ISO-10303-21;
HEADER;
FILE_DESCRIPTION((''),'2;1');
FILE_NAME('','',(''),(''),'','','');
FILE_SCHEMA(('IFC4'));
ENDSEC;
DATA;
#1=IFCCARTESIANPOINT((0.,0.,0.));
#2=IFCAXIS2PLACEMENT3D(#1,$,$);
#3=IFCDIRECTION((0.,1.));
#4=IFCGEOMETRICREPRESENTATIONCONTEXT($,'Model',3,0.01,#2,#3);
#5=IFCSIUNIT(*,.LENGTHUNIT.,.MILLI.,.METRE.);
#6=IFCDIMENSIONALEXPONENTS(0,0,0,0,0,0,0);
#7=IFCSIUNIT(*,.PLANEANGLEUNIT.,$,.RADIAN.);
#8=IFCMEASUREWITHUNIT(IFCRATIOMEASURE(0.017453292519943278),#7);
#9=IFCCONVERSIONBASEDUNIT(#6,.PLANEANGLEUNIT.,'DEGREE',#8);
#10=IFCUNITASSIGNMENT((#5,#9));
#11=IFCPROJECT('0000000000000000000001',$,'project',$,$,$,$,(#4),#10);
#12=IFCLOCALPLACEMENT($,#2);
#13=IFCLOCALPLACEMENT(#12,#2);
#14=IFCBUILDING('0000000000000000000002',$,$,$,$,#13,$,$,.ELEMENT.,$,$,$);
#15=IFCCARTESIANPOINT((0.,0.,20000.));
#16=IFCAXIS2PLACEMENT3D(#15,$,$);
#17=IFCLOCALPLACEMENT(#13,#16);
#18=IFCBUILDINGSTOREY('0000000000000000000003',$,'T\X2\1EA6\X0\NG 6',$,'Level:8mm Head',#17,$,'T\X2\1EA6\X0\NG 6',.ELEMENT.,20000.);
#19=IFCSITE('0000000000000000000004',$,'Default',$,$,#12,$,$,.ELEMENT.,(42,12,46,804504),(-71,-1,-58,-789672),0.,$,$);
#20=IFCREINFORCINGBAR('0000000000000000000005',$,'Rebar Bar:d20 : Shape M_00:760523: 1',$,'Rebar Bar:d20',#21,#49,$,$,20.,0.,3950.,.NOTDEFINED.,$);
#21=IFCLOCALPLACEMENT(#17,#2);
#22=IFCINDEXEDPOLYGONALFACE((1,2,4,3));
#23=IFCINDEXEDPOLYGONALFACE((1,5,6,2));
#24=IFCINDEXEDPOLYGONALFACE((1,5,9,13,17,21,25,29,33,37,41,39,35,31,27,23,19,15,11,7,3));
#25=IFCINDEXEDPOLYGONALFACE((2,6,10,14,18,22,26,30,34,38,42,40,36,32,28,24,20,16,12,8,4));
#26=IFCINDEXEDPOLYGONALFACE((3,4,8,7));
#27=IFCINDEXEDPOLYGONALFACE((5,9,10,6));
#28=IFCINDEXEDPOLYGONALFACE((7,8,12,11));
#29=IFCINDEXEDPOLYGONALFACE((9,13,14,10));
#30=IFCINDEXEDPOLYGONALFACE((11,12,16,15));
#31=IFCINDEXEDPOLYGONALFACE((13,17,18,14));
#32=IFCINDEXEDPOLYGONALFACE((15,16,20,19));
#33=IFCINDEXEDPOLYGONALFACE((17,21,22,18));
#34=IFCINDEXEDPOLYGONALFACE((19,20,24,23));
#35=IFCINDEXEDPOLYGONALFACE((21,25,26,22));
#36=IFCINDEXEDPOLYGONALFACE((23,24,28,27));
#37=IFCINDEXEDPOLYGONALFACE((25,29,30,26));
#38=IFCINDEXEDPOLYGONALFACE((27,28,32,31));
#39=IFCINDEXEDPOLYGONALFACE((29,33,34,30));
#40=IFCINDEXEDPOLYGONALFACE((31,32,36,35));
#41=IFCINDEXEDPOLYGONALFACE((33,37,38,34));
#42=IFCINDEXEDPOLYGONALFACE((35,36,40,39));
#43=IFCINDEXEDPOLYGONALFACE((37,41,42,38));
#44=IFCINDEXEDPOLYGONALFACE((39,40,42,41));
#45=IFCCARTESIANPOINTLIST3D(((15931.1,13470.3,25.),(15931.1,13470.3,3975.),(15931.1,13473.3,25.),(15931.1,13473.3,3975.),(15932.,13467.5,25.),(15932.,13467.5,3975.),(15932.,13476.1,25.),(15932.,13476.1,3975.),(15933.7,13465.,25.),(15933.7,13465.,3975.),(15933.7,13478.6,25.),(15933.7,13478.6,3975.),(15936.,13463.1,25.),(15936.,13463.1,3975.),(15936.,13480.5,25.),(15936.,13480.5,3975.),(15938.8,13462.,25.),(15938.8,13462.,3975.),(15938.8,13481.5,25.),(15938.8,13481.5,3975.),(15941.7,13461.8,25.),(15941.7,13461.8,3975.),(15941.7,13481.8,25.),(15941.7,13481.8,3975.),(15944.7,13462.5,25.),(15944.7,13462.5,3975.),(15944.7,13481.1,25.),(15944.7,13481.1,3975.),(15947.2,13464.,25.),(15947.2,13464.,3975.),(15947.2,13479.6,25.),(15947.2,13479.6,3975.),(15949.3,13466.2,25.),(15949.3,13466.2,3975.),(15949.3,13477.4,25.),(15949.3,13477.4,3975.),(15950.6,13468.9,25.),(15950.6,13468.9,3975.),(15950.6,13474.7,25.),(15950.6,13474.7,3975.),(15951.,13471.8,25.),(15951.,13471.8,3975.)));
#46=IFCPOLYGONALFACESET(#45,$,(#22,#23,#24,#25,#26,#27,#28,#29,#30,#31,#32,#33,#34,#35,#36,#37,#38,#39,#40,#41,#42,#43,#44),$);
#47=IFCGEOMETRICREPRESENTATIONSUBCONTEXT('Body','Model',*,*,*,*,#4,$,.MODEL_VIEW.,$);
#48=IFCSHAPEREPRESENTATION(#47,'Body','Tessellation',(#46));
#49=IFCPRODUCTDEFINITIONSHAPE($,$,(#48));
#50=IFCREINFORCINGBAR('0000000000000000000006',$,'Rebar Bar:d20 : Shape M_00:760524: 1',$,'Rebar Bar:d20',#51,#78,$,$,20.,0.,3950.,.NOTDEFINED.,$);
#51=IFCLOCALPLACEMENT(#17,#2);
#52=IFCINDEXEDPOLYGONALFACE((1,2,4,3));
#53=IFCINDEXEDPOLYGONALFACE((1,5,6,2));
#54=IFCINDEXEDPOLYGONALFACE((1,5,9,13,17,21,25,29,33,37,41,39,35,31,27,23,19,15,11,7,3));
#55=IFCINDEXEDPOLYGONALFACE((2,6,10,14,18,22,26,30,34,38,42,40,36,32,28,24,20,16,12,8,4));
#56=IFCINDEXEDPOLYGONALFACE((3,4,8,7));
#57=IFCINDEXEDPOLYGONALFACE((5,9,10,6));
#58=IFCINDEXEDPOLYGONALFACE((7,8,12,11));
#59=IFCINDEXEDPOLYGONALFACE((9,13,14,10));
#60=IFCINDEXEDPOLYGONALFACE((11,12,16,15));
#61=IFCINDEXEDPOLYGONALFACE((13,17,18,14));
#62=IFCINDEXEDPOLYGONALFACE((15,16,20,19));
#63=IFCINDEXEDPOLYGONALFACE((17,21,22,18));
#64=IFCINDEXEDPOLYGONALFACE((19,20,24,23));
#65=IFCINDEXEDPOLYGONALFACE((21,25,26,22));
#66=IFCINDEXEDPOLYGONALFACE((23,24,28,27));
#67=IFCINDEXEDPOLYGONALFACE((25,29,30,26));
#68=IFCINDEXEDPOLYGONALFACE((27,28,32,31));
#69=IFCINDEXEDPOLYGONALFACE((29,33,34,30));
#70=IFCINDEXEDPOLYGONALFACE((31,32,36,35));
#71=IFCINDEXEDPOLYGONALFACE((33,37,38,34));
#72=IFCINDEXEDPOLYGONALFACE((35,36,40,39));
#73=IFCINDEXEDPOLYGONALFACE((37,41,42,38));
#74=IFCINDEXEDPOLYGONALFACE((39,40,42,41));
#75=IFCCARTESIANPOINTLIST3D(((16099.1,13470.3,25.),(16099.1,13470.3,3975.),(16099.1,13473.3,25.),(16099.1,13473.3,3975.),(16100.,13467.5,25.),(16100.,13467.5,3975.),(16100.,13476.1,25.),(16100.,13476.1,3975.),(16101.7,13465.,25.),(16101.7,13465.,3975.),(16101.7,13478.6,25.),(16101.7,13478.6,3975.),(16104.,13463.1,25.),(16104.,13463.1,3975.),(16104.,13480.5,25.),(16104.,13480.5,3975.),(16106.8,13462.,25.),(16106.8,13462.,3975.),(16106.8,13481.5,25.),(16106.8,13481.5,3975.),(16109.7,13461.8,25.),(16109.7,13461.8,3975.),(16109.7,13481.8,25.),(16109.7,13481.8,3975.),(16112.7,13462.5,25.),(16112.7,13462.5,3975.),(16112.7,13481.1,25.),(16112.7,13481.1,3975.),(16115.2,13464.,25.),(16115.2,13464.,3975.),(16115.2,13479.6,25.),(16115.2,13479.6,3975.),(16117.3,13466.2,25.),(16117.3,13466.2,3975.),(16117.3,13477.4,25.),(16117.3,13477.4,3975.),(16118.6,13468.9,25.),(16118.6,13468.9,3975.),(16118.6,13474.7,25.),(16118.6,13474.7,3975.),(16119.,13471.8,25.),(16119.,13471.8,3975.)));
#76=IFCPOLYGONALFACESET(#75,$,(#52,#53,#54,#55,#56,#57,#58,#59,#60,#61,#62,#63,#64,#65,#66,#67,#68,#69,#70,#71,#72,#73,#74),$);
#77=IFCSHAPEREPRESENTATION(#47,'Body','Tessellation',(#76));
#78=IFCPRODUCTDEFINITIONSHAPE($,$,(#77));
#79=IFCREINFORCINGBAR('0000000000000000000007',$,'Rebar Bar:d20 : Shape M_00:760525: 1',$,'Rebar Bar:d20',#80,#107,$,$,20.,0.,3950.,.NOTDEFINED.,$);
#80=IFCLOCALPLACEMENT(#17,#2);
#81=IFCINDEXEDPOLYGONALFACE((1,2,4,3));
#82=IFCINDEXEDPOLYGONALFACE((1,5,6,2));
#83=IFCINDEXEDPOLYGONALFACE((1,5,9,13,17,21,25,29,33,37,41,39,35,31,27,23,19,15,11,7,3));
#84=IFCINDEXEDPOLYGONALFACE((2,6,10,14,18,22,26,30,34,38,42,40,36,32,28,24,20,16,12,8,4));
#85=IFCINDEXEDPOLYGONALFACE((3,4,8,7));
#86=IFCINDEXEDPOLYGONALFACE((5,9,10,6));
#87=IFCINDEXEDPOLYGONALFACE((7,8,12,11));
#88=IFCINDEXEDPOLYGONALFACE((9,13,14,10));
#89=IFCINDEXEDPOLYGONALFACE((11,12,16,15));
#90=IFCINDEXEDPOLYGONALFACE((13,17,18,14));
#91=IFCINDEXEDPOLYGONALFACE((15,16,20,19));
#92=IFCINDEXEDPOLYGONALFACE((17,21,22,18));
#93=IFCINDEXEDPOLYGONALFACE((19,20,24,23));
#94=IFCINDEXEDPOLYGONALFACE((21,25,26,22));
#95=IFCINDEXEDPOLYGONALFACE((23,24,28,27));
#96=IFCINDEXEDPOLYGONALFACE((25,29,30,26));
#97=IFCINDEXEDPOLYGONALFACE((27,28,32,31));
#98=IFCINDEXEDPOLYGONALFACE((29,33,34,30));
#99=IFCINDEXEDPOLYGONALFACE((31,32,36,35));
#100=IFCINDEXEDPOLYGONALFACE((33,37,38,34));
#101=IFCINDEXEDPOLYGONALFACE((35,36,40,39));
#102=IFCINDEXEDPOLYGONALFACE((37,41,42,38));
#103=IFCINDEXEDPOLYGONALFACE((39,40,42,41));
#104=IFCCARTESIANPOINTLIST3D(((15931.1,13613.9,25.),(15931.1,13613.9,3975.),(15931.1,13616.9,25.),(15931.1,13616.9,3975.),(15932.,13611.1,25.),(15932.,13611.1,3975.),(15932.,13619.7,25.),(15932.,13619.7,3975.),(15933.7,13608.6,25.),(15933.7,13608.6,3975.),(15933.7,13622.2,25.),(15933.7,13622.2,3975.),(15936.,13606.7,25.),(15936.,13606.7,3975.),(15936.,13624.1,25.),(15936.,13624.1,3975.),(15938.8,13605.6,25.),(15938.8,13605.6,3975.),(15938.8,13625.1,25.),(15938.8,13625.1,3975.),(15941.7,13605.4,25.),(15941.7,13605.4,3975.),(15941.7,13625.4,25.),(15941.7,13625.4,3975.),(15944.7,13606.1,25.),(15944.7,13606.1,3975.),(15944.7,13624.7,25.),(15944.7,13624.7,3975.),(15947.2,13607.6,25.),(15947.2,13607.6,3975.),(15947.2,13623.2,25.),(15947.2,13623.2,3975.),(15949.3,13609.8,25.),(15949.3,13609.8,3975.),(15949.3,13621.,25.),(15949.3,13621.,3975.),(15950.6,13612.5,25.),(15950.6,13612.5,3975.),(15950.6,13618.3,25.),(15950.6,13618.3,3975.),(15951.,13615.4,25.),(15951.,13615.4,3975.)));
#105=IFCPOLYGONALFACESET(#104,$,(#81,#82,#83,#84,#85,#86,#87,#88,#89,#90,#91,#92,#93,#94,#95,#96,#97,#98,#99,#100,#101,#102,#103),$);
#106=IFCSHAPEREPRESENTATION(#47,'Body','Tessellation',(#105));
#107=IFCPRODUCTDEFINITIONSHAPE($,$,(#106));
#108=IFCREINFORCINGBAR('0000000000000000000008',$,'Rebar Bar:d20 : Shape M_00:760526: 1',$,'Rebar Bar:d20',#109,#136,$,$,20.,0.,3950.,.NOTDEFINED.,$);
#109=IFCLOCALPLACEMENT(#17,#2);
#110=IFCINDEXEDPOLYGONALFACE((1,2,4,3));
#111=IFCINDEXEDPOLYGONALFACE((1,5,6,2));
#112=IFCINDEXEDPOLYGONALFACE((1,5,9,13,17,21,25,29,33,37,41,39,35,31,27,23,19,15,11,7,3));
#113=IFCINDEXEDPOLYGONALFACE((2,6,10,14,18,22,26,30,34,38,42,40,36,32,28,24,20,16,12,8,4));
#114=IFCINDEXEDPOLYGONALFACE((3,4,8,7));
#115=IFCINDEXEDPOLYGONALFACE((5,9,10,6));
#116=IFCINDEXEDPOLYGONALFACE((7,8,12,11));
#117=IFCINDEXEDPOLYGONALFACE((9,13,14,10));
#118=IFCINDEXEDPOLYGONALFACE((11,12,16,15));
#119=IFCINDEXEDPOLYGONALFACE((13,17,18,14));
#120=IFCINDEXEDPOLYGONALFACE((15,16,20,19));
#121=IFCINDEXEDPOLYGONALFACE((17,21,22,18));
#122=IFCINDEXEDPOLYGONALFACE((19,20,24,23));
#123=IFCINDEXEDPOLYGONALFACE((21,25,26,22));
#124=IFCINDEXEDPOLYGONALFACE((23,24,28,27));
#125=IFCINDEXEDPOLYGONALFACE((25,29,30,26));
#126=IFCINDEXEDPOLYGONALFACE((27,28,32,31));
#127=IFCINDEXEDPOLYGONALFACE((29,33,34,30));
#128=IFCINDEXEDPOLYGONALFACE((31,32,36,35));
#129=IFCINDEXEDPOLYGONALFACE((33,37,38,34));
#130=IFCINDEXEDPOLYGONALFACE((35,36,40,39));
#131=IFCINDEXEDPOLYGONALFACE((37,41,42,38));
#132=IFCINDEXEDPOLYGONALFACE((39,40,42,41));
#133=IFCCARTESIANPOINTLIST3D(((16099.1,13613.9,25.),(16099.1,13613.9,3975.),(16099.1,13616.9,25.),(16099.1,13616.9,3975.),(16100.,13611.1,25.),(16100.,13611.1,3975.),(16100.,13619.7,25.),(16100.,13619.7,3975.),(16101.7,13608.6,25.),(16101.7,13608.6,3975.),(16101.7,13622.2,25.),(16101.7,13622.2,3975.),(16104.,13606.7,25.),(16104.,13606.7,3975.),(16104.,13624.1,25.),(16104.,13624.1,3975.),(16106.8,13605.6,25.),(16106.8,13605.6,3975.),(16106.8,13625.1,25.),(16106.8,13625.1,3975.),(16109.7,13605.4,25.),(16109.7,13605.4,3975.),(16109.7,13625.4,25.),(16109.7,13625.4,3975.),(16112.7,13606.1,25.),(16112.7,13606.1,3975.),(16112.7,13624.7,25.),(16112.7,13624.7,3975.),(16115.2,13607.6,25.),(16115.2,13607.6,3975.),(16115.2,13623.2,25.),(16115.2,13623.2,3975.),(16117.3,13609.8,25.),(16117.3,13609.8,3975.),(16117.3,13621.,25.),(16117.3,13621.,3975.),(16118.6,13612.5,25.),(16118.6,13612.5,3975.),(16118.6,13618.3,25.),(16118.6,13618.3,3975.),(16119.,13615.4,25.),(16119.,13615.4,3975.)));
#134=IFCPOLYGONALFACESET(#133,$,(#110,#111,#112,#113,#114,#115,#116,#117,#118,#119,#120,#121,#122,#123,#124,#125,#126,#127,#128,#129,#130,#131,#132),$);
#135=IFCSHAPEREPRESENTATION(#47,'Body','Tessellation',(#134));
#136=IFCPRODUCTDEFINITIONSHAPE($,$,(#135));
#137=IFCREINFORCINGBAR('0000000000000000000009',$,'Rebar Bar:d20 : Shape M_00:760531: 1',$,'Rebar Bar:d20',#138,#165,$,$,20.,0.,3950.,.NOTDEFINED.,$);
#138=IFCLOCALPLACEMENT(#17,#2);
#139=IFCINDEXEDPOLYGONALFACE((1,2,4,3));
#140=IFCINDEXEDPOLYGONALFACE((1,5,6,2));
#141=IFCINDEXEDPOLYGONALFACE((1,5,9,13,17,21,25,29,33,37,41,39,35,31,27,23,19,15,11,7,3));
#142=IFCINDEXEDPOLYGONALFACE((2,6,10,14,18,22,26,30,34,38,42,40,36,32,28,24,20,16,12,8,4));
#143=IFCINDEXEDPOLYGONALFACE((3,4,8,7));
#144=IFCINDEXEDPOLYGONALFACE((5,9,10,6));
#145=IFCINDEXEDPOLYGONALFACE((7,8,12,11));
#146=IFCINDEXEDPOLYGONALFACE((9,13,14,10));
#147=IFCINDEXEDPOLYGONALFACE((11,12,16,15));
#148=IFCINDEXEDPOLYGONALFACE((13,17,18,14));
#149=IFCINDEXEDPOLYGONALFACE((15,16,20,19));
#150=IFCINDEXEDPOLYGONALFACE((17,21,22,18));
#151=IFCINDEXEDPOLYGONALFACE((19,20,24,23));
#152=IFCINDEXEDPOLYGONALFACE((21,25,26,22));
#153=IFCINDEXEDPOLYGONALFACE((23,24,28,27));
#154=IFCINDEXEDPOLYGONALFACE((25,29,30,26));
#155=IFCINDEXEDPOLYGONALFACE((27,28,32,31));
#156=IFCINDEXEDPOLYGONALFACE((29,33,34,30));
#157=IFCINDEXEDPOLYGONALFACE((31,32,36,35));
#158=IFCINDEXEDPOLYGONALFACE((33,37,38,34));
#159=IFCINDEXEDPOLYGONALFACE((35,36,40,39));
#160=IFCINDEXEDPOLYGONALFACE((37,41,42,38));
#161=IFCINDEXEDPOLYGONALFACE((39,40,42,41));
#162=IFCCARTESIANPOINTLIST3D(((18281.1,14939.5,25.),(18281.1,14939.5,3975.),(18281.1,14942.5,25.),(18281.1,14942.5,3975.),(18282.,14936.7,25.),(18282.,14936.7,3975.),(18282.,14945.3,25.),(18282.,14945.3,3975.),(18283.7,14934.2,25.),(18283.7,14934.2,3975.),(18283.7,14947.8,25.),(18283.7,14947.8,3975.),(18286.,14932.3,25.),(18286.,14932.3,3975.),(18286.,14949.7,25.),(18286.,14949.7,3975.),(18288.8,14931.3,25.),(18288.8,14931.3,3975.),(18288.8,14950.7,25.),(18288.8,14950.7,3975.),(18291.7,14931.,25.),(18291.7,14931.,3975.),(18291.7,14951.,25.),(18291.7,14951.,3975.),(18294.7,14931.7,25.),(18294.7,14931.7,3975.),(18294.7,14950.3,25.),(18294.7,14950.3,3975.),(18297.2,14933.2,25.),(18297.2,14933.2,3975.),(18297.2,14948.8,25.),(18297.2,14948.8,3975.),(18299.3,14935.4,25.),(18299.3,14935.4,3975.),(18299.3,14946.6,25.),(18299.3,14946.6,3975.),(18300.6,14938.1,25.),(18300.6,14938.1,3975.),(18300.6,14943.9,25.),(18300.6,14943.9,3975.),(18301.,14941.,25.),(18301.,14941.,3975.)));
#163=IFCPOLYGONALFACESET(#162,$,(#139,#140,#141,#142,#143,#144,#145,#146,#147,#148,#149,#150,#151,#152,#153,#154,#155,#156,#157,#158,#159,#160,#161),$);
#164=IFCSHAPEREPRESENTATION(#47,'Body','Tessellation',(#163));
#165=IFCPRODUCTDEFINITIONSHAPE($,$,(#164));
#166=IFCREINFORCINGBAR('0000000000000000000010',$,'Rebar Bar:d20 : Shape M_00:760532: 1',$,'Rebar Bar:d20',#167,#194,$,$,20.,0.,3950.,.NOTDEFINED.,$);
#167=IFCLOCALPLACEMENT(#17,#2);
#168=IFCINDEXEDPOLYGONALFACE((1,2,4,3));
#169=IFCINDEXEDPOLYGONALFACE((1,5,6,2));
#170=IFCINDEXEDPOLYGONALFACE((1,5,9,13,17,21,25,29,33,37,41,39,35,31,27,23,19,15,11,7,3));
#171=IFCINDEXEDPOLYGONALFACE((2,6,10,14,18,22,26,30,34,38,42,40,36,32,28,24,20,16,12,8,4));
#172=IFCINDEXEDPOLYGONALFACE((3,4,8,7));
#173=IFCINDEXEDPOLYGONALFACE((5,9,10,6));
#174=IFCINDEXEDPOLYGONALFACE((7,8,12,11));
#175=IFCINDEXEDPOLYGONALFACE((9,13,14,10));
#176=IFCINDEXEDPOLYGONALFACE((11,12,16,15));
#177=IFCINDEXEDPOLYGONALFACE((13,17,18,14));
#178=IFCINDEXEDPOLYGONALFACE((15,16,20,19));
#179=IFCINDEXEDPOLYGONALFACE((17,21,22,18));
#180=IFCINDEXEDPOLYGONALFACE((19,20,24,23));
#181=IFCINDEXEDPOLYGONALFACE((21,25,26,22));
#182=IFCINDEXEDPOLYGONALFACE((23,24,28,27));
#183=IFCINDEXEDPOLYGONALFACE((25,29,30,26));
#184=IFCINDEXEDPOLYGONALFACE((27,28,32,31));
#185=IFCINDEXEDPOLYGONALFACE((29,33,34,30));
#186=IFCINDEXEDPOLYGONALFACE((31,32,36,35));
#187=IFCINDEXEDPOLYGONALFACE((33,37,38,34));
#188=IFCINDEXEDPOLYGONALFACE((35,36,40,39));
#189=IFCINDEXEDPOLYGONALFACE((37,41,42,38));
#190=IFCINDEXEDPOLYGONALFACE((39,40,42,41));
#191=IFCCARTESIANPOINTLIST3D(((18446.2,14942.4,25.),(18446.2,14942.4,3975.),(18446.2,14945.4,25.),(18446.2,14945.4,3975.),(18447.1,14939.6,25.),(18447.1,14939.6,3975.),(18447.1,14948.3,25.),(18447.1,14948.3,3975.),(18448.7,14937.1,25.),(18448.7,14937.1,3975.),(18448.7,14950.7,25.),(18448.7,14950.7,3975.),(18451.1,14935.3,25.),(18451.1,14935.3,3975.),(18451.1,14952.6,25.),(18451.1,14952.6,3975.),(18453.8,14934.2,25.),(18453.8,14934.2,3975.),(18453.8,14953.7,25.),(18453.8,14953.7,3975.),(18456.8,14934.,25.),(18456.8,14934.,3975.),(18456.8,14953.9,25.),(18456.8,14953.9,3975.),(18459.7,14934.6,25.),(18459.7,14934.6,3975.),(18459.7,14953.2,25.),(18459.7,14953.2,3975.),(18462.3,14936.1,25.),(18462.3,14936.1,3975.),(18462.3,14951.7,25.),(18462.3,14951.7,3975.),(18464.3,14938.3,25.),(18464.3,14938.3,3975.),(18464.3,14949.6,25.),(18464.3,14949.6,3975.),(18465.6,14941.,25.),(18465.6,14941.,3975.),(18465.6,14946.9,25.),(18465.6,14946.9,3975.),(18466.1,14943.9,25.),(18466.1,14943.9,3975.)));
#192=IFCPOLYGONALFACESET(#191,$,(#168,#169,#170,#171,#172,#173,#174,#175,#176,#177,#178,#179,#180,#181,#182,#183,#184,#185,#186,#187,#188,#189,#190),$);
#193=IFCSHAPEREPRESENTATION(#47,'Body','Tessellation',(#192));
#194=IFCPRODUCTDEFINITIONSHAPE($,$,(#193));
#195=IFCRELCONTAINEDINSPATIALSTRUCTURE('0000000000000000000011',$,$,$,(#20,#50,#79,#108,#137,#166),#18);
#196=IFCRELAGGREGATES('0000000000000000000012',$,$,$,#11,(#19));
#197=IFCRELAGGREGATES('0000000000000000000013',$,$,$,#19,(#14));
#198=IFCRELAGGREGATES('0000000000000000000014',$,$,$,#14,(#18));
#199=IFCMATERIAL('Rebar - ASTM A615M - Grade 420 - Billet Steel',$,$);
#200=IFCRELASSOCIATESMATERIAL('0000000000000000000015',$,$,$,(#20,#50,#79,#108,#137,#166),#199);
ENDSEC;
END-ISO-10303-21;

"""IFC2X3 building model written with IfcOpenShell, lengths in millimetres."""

from ifc_helpers import new_model, entity, si_unit, converted_unit, direction, frame, origin, place, context, subcontext, project, spatial, material, element, save


model = new_model("IFC2X3")

# Units and contexts
model_context = context("Model", 3, precision=0.01, world=origin(), true_north=direction((0.0, 1.0)))
body_context = subcontext(model_context, "Body", "Model", "MODEL_VIEW")
ifc_project = project(units=[si_unit("LENGTHUNIT", "METRE", prefix="MILLI"), converted_unit("PLANEANGLEUNIT", "DEGREE", entity("IfcRatioMeasure", 0.017453292519943278), si_unit("PLANEANGLEUNIT", "RADIAN"), dimensions=[0, 0, 0, 0, 0, 0, 0])], contexts=[model_context])

# Site, building, storey
site_placement = place(None, origin())
site = spatial("IfcSite", under=ifc_project, at=site_placement, Name="Default", CompositionType="ELEMENT", RefLatitude=(42, 12, 46, 804504), RefLongitude=(-71, -1, -58, -789672), RefElevation=0.0)
building_placement = place(site_placement, origin())
building = spatial("IfcBuilding", under=site, at=building_placement, CompositionType="ELEMENT")
storey_placement = place(building_placement, frame((0.0, 0.0, 20000.0)))
storey = spatial("IfcBuildingStorey", under=building, at=storey_placement, Name="TẦNG 6", ObjectType="Level:8mm Head", LongName="TẦNG 6", CompositionType="ELEMENT", Elevation=20000.0)

# Reinforcing bars
ifc_material = material(Name="Rebar - ASTM A615M - Grade 420 - Billet Steel")
reinforcing_bar_1_placement = place(storey_placement, origin())
element("IfcReinforcingBar", 1, at=reinforcing_bar_1_placement, inside=storey, material=ifc_material, Name="Rebar Bar:d20 : Shape M_00:760523: 1", ObjectType="Rebar Bar:d20", BarLength=3950.0, BarRole="NOTDEFINED", CrossSectionArea=0.0, NominalDiameter=20.0, context=body_context, shape_type="AdvancedSweptSolid", body=[
    entity("IfcSweptDiskSolid", entity("IfcCompositeCurve", [entity("IfcCompositeCurveSegment", "CONTINUOUS", True, entity("IfcPolyline", [entity("IfcCartesianPoint", [15941.0, 13471.8, 25.0]), entity("IfcCartesianPoint", [15941.0, 13471.8, 3975.0])]))], False), 10.0, None, 0.0, 1.0),
])
reinforcing_bar_2_placement = place(storey_placement, origin())
element("IfcReinforcingBar", 2, at=reinforcing_bar_2_placement, inside=storey, material=ifc_material, Name="Rebar Bar:d20 : Shape M_00:760524: 1", ObjectType="Rebar Bar:d20", BarLength=3950.0, BarRole="NOTDEFINED", CrossSectionArea=0.0, NominalDiameter=20.0, context=body_context, shape_type="AdvancedSweptSolid", body=[
    entity("IfcSweptDiskSolid", entity("IfcCompositeCurve", [entity("IfcCompositeCurveSegment", "CONTINUOUS", True, entity("IfcPolyline", [entity("IfcCartesianPoint", [16109.0, 13471.8, 25.0]), entity("IfcCartesianPoint", [16109.0, 13471.8, 3975.0])]))], False), 10.0, None, 0.0, 1.0),
])
reinforcing_bar_3_placement = place(storey_placement, origin())
element("IfcReinforcingBar", 3, at=reinforcing_bar_3_placement, inside=storey, material=ifc_material, Name="Rebar Bar:d20 : Shape M_00:760525: 1", ObjectType="Rebar Bar:d20", BarLength=3950.0, BarRole="NOTDEFINED", CrossSectionArea=0.0, NominalDiameter=20.0, context=body_context, shape_type="AdvancedSweptSolid", body=[
    entity("IfcSweptDiskSolid", entity("IfcCompositeCurve", [entity("IfcCompositeCurveSegment", "CONTINUOUS", True, entity("IfcPolyline", [entity("IfcCartesianPoint", [15941.0, 13615.4, 25.0]), entity("IfcCartesianPoint", [15941.0, 13615.4, 3975.0])]))], False), 10.0, None, 0.0, 1.0),
])
reinforcing_bar_4_placement = place(storey_placement, origin())
element("IfcReinforcingBar", 4, at=reinforcing_bar_4_placement, inside=storey, material=ifc_material, Name="Rebar Bar:d20 : Shape M_00:760526: 1", ObjectType="Rebar Bar:d20", BarLength=3950.0, BarRole="NOTDEFINED", CrossSectionArea=0.0, NominalDiameter=20.0, context=body_context, shape_type="AdvancedSweptSolid", body=[
    entity("IfcSweptDiskSolid", entity("IfcCompositeCurve", [entity("IfcCompositeCurveSegment", "CONTINUOUS", True, entity("IfcPolyline", [entity("IfcCartesianPoint", [16109.0, 13615.4, 25.0]), entity("IfcCartesianPoint", [16109.0, 13615.4, 3975.0])]))], False), 10.0, None, 0.0, 1.0),
])
reinforcing_bar_5_placement = place(storey_placement, origin())
element("IfcReinforcingBar", 5, at=reinforcing_bar_5_placement, inside=storey, material=ifc_material, Name="Rebar Bar:d20 : Shape M_00:760531: 1", ObjectType="Rebar Bar:d20", BarLength=3950.0, BarRole="NOTDEFINED", CrossSectionArea=0.0, NominalDiameter=20.0, context=body_context, shape_type="AdvancedSweptSolid", body=[
    entity("IfcSweptDiskSolid", entity("IfcCompositeCurve", [entity("IfcCompositeCurveSegment", "CONTINUOUS", True, entity("IfcPolyline", [entity("IfcCartesianPoint", [18291.0, 14941.0, 25.0]), entity("IfcCartesianPoint", [18291.0, 14941.0, 3975.0])]))], False), 10.0, None, 0.0, 1.0),
])
reinforcing_bar_6_placement = place(storey_placement, origin())
element("IfcReinforcingBar", 6, at=reinforcing_bar_6_placement, inside=storey, material=ifc_material, Name="Rebar Bar:d20 : Shape M_00:760532: 1", ObjectType="Rebar Bar:d20", BarLength=3950.0, BarRole="NOTDEFINED", CrossSectionArea=0.0, NominalDiameter=20.0, context=body_context, shape_type="AdvancedSweptSolid", body=[
    entity("IfcSweptDiskSolid", entity("IfcCompositeCurve", [entity("IfcCompositeCurveSegment", "CONTINUOUS", True, entity("IfcPolyline", [entity("IfcCartesianPoint", [18456.1, 14943.9, 25.0]), entity("IfcCartesianPoint", [18456.1, 14943.9, 3975.0])]))], False), 10.0, None, 0.0, 1.0),
])

save(model, "model.ifc")
